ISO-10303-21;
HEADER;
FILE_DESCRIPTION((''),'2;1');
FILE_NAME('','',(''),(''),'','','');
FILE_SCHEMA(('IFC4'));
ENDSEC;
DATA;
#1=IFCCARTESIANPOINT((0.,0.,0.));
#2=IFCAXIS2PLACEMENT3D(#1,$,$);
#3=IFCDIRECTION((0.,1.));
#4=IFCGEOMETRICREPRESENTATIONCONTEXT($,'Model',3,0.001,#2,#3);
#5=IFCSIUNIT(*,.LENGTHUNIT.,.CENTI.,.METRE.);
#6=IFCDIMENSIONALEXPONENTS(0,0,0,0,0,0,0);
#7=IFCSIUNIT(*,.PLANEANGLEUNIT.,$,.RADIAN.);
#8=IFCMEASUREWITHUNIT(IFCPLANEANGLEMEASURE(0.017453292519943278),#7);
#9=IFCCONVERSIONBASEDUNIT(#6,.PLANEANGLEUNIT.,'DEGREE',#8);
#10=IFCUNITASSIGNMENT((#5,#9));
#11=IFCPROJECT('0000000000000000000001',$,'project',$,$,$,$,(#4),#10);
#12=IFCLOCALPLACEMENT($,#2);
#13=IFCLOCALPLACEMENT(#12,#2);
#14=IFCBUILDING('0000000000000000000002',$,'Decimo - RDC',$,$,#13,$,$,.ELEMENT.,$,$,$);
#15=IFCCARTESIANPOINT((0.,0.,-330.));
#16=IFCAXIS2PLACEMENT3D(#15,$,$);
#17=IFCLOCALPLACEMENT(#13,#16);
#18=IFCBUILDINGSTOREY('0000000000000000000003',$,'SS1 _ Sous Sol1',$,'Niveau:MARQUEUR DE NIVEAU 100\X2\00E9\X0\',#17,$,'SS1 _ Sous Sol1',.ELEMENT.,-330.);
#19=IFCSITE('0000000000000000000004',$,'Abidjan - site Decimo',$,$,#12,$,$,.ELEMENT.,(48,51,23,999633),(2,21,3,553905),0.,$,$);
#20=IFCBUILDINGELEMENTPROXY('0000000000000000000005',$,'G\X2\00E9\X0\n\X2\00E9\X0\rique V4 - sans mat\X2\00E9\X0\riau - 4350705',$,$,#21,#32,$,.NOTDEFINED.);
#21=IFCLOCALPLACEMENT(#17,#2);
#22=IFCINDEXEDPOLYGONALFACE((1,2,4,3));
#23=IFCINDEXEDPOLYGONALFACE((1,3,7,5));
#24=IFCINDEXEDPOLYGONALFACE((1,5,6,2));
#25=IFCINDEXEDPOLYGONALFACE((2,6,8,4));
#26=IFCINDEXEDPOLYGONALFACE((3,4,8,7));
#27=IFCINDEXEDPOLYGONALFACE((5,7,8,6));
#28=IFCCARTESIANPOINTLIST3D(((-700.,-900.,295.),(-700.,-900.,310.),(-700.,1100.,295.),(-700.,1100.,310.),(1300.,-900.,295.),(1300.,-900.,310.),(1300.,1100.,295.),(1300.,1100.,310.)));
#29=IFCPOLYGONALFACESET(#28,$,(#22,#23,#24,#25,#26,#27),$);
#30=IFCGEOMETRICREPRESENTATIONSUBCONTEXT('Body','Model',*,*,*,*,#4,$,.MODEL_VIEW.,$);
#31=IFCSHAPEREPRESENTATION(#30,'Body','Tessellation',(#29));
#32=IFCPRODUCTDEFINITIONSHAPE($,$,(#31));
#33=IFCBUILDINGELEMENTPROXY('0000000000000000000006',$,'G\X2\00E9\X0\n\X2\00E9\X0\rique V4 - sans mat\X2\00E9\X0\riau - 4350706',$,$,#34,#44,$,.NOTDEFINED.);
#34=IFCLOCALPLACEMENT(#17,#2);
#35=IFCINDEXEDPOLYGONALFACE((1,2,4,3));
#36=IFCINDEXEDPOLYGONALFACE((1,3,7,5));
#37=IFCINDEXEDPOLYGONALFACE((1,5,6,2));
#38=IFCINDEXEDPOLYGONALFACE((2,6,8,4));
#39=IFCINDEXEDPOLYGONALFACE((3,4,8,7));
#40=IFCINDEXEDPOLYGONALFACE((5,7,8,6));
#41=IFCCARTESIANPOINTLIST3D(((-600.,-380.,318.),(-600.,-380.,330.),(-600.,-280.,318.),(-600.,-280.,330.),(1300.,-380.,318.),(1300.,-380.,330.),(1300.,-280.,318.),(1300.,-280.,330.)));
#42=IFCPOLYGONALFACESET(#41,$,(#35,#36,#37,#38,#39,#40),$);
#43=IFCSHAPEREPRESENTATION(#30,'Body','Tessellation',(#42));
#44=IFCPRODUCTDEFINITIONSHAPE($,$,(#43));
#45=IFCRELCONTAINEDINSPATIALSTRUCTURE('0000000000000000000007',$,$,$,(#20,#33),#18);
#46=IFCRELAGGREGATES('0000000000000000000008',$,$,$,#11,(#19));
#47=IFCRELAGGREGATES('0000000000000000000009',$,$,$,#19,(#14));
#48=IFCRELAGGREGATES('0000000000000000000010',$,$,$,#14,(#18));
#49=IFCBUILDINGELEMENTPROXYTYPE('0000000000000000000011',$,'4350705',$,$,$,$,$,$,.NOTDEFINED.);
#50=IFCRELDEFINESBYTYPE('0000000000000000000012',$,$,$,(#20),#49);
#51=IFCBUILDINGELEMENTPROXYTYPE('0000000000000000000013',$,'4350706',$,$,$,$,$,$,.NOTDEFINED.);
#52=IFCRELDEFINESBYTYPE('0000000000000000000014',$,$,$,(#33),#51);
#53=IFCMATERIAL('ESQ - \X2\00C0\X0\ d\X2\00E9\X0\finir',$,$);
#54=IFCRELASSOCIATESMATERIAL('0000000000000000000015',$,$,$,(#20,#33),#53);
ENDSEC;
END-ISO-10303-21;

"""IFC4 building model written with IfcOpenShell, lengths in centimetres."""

from ifc_helpers import new_model, entity, si_unit, converted_unit, direction, frame, frame_2d, origin, origin_2d_with_axis, place, context, subcontext, project, spatial, rectangle, extrude, material, type_object, element, save


model = new_model("IFC4")

# Units and contexts
model_context = context("Model", 3, precision=0.001, world=origin(), true_north=direction((0.0, 1.0)))
body_context = subcontext(model_context, "Body", "Model", "MODEL_VIEW")
ifc_project = project(units=[si_unit("LENGTHUNIT", "METRE", prefix="CENTI"), converted_unit("PLANEANGLEUNIT", "DEGREE", entity("IfcPlaneAngleMeasure", 0.017453292519943278), si_unit("PLANEANGLEUNIT", "RADIAN"), dimensions=[0, 0, 0, 0, 0, 0, 0])], contexts=[model_context])

# Site, building, storey
site_placement = place(None, origin())
site = spatial("IfcSite", under=ifc_project, at=site_placement, Name="Abidjan - site Decimo", CompositionType="ELEMENT", RefLatitude=(48, 51, 23, 999633), RefLongitude=(2, 21, 3, 553905), RefElevation=0.0)
building_placement = place(site_placement, origin())
building = spatial("IfcBuilding", under=site, at=building_placement, Name="Decimo - RDC", CompositionType="ELEMENT")
storey_placement = place(building_placement, frame((0.0, 0.0, -330.0)))
storey = spatial("IfcBuildingStorey", under=building, at=storey_placement, Name="SS1 _ Sous Sol1", ObjectType="Niveau:MARQUEUR DE NIVEAU 100é", LongName="SS1 _ Sous Sol1", CompositionType="ELEMENT", Elevation=-330.0)

# Building element proxies
ifc_material = material(Name="ESQ - À définir")
building_element_proxy_type_1 = type_object("IfcBuildingElementProxyType", Name="4350705", PredefinedType="NOTDEFINED")
proxy_1_placement = place(storey_placement, origin())
element("IfcBuildingElementProxy", 1, at=proxy_1_placement, inside=storey, type_object=building_element_proxy_type_1, material=ifc_material, Name="Générique V4 - sans matériau - 4350705", PredefinedType="NOTDEFINED", context=body_context, shape_type="SweptSolid", body=[
    extrude(rectangle(XDim=2000.0, YDim=2000.0, at=frame_2d((0.0, 0.0), x_axis=(1.0, 0.0))), frame((300.0, 100.0, 295.0)), (0.0, 0.0, 1.0), 15.0),
])
building_element_proxy_type_2 = type_object("IfcBuildingElementProxyType", Name="4350706", PredefinedType="NOTDEFINED")
proxy_2_placement = place(storey_placement, origin())
element("IfcBuildingElementProxy", 2, at=proxy_2_placement, inside=storey, type_object=building_element_proxy_type_2, material=ifc_material, Name="Générique V4 - sans matériau - 4350706", PredefinedType="NOTDEFINED", context=body_context, shape_type="SweptSolid", body=[
    extrude(rectangle(XDim=1900.0, YDim=100.0, at=origin_2d_with_axis()), frame((350.0, -330.0, 318.0)), (0.0, 0.0, 1.0), 12.0),
])

save(model, "model.ifc")
